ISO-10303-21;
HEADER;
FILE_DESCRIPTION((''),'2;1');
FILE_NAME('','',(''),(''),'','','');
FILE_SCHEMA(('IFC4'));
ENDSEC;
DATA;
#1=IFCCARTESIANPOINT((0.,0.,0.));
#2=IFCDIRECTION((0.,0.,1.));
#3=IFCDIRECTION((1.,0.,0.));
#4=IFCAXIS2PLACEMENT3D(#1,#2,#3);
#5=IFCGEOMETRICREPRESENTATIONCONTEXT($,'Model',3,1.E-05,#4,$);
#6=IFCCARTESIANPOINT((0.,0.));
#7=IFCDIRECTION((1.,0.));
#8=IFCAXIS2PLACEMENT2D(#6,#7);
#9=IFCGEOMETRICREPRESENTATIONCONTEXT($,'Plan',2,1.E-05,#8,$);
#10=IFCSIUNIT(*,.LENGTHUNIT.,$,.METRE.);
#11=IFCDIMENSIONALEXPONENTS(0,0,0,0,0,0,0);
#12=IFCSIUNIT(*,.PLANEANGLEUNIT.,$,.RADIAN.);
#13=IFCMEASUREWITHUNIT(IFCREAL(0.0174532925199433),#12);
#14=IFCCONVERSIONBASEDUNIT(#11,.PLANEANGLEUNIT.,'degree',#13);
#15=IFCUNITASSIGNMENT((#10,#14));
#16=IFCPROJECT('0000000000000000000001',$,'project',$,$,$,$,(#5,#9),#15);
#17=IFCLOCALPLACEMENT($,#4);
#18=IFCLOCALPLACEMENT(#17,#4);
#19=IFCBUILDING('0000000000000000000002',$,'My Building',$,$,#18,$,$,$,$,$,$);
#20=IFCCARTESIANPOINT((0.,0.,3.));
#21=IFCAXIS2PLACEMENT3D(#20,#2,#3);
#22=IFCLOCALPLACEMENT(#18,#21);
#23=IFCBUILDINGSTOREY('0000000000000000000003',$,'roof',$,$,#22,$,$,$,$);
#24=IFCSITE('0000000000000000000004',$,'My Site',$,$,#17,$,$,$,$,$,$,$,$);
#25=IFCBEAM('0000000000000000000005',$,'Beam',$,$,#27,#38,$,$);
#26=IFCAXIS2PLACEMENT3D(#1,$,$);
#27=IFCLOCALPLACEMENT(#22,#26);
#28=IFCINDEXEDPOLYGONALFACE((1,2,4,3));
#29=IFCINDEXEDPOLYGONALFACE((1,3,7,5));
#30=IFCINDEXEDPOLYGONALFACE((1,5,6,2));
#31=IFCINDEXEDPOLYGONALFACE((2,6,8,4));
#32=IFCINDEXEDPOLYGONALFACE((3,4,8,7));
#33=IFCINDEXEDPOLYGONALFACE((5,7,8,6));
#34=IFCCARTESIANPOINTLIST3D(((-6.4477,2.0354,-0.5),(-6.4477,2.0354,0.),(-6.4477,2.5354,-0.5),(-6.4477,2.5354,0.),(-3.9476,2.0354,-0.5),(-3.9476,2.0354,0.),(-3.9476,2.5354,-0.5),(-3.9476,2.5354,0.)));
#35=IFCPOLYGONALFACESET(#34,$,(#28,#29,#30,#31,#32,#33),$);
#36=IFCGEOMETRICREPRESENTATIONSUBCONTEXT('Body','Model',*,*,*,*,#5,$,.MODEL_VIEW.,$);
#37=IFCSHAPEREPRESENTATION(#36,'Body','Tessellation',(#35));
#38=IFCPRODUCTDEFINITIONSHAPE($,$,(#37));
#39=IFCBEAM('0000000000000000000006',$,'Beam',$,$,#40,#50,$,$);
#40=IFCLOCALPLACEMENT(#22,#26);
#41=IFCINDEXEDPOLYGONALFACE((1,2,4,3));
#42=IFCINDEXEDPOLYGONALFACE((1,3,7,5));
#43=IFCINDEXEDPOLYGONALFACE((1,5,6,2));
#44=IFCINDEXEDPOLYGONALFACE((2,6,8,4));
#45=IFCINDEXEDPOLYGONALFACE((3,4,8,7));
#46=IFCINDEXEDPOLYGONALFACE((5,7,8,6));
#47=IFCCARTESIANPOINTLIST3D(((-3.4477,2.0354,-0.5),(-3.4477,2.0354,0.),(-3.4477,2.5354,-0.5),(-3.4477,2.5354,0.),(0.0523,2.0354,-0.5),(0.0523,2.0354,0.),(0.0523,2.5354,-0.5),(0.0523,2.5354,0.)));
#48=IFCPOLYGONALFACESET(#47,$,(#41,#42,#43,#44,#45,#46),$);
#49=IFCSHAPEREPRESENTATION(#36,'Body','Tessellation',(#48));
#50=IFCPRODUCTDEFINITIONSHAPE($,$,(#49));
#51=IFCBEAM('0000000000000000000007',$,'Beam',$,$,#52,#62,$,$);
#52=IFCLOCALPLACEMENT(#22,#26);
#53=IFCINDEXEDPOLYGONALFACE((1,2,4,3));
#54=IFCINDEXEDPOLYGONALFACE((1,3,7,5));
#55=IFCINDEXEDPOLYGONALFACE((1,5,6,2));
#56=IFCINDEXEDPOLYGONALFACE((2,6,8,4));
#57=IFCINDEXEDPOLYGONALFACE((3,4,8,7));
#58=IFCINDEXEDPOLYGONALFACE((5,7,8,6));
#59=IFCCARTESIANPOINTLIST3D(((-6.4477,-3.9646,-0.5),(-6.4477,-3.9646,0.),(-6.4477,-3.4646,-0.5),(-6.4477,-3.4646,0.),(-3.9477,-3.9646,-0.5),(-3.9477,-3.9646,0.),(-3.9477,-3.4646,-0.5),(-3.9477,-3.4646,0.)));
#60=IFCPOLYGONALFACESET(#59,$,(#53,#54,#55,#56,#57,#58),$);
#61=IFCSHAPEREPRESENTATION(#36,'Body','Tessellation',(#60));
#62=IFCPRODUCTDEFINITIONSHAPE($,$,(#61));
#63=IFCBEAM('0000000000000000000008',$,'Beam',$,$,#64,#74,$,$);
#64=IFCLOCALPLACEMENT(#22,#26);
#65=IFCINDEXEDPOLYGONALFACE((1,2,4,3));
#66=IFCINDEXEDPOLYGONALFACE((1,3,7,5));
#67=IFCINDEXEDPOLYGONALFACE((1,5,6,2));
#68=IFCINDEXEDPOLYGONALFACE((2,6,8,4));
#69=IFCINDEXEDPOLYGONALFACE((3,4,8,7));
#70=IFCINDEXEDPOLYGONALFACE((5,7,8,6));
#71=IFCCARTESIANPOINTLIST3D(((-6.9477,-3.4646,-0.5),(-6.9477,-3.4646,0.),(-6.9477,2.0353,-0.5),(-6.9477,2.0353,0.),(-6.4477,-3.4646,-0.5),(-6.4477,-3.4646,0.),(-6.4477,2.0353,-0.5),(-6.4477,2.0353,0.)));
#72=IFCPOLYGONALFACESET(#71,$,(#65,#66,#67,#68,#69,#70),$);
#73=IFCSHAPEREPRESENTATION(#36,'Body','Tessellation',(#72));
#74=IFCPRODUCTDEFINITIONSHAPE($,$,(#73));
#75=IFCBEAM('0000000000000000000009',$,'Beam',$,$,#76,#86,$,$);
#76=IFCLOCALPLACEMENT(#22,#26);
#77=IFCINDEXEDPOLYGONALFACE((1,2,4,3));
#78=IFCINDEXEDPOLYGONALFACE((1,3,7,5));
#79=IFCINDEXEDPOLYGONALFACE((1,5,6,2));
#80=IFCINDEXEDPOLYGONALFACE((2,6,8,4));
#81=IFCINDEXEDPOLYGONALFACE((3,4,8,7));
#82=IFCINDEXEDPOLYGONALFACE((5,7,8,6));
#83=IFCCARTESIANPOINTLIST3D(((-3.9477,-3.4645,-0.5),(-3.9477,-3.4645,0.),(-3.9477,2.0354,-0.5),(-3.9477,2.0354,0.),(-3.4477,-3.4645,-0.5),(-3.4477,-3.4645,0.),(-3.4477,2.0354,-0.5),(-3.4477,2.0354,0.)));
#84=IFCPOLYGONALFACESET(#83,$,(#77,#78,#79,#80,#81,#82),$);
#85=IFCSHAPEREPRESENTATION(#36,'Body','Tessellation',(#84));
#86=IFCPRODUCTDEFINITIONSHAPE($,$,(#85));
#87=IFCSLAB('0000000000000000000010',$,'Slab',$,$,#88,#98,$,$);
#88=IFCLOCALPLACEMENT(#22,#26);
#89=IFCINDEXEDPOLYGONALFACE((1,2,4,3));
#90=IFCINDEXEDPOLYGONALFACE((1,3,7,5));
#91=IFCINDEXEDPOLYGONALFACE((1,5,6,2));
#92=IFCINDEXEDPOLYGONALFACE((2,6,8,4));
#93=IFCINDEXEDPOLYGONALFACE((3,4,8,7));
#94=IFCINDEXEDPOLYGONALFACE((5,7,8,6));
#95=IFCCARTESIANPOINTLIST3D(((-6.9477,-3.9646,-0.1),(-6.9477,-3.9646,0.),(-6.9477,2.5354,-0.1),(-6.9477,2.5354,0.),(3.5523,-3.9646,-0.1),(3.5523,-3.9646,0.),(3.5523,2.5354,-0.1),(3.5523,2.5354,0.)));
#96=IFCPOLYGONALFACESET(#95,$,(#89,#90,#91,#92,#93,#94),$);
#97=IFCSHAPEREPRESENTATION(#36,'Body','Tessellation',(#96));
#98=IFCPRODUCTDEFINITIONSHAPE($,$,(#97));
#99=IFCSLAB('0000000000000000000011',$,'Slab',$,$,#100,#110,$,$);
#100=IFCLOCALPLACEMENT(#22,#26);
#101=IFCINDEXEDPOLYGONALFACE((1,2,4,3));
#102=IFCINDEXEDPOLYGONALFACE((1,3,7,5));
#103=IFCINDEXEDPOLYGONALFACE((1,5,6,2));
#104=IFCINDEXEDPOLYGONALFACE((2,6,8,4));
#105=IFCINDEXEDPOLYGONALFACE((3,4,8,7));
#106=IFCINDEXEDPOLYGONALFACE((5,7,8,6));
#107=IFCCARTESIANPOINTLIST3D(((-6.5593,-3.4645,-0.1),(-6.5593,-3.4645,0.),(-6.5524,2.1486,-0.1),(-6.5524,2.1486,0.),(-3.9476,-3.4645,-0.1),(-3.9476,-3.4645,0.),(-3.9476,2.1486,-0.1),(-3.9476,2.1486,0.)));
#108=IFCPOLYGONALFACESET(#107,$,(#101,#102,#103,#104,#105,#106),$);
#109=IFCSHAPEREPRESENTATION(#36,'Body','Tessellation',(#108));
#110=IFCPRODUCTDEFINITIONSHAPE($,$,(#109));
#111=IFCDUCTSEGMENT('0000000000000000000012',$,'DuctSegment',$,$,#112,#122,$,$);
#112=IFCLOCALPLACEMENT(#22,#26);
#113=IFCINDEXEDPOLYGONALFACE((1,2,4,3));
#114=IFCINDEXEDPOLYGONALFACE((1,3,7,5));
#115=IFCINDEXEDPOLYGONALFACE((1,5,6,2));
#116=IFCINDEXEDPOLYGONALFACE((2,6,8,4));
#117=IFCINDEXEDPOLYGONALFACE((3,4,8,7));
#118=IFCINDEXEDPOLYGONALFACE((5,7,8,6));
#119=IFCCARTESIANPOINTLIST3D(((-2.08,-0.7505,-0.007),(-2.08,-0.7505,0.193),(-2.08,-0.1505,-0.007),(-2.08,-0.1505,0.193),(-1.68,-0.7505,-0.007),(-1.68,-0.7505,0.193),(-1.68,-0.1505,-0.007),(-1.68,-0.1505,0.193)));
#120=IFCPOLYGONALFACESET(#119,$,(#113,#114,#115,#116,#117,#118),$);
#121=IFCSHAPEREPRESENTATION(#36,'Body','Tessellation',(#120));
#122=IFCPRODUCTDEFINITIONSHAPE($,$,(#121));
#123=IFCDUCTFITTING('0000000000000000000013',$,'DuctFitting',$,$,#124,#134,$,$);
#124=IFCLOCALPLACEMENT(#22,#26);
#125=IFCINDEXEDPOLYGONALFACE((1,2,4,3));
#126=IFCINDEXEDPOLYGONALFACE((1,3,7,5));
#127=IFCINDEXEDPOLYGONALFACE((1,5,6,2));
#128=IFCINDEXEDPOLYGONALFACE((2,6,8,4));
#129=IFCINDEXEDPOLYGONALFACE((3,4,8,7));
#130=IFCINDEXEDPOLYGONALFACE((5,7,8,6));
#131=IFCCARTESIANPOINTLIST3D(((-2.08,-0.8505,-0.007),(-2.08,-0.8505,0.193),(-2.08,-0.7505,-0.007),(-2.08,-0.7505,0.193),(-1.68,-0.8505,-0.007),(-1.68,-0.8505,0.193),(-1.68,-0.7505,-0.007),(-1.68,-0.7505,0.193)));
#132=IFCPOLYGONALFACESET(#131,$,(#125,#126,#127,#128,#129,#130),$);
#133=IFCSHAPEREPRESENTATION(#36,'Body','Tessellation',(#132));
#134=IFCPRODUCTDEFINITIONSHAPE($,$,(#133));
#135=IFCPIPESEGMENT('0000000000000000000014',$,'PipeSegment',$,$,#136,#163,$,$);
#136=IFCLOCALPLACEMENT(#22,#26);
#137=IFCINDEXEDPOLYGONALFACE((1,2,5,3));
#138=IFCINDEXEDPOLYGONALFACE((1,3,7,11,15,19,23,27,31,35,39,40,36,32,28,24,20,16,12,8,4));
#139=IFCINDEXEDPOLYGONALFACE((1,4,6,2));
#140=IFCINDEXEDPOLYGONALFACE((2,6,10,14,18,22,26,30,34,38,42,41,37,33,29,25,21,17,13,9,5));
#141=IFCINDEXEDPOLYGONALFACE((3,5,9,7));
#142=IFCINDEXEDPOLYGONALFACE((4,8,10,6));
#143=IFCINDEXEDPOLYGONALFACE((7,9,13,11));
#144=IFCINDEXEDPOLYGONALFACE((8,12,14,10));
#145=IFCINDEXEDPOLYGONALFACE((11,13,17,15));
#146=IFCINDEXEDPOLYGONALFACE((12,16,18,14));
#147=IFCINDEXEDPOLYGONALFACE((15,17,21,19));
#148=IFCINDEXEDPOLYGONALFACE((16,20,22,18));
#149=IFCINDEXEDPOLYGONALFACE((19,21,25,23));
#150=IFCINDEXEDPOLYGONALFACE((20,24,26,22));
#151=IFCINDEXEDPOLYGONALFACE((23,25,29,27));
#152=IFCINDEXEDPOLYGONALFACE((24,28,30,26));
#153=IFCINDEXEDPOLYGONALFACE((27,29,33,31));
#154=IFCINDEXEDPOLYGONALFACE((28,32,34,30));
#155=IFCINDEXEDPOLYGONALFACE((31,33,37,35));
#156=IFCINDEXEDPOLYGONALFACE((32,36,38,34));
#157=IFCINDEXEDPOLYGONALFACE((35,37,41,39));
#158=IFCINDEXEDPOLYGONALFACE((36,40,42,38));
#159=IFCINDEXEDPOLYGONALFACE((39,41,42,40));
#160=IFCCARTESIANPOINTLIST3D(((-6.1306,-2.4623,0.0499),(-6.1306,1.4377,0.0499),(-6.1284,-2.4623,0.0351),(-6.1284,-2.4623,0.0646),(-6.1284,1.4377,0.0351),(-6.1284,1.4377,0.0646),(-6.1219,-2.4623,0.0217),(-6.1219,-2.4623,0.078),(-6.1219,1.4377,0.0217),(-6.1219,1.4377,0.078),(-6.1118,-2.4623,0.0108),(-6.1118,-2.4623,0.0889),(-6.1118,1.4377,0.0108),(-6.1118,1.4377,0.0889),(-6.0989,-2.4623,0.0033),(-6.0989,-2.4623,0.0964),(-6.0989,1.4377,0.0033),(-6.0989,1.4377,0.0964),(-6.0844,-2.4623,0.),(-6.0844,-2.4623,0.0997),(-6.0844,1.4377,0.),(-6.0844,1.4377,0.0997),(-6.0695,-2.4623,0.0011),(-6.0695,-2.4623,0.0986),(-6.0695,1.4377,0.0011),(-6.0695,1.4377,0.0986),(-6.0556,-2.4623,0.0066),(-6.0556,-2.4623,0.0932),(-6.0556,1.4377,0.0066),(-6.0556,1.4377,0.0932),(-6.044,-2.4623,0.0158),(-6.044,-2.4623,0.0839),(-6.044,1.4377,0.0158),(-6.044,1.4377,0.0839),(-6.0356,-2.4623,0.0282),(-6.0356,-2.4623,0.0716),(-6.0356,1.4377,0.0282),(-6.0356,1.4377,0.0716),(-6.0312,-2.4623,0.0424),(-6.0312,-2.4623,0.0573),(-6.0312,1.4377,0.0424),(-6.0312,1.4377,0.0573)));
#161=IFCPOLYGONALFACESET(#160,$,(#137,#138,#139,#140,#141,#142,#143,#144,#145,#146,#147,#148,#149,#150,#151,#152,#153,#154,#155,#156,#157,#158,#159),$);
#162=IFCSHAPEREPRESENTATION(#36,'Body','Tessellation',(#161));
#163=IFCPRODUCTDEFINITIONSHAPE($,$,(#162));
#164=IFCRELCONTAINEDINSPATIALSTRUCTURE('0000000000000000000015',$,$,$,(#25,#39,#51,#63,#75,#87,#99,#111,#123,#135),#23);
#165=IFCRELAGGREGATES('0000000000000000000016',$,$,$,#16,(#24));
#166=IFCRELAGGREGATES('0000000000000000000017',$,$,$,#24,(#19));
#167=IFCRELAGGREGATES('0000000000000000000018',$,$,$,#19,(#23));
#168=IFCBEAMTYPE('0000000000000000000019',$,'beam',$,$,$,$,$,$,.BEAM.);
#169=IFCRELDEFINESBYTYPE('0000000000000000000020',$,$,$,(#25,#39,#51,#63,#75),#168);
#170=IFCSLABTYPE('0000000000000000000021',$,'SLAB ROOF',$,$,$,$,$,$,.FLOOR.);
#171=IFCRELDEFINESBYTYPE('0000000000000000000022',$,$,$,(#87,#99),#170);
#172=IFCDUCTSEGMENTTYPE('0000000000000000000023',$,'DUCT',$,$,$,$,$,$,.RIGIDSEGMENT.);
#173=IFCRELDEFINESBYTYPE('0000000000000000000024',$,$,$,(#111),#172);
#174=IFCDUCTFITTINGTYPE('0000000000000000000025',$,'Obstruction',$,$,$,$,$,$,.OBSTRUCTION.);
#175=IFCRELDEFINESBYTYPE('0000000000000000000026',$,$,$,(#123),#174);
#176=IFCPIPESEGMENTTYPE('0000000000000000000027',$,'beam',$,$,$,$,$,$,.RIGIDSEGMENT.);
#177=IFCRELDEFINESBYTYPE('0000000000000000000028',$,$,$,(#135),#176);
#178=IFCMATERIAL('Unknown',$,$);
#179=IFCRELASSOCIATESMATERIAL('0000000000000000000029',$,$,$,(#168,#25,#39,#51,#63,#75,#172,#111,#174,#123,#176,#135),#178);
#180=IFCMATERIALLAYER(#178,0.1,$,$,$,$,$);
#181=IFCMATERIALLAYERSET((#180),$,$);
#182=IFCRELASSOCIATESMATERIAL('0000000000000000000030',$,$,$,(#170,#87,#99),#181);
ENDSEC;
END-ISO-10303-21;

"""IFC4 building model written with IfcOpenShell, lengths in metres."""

from ifc_helpers import new_model, entity, si_unit, converted_unit, frame, origin_with_axes, origin_2d_with_axis, place, context, subcontext, project, spatial, indexed_curve, rectangle, circle, outline, extrude, material, layer, layer_set, layer_usage, material_profile, profile_set, profile_usage, type_object, element, save


model = new_model("IFC4")

# Units and contexts
model_context = context("Model", 3, precision=1e-05, world=origin_with_axes())
plan_context = context("Plan", 2, precision=1e-05, world=origin_2d_with_axis())
body_context = subcontext(model_context, "Body", "Model", "MODEL_VIEW")
ifc_project = project(units=[si_unit("LENGTHUNIT", "METRE"), converted_unit("PLANEANGLEUNIT", "degree", entity("IfcReal", 0.0174532925199433), si_unit("PLANEANGLEUNIT", "RADIAN"), dimensions=[0, 0, 0, 0, 0, 0, 0])], contexts=[model_context, plan_context])

# Site, building, storey
site_placement = place(None, origin_with_axes())
site = spatial("IfcSite", under=ifc_project, at=site_placement, Name="My Site")
building_placement = place(site_placement, origin_with_axes())
building = spatial("IfcBuilding", under=site, at=building_placement, Name="My Building")
storey_placement = place(building_placement, frame((0.0, 0.0, 3.0), z_axis=(0.0, 0.0, 1.0), x_axis=(1.0, 0.0, 0.0)))
storey = spatial("IfcBuildingStorey", under=building, at=storey_placement, Name="roof")

# Beams
ifc_material = material(Name="Unknown")
ifc_material_profile_1 = material_profile(ifc_material, rectangle(XDim=0.5, YDim=0.5))
ifc_profile_set_1 = profile_set([ifc_material_profile_1])
ifc_profile_usage_1 = profile_usage(ifc_profile_set_1, cardinal=7)
beam_type = type_object("IfcBeamType", Name="beam", PredefinedType="BEAM", material=ifc_profile_set_1)
beam_1_placement = place(storey_placement, frame((-6.4477, 2.5354, 0.0), z_axis=(1.0, 0.0, 0.0), x_axis=(0.0, 1.0, 0.0)))
element("IfcBeam", 1, at=beam_1_placement, inside=storey, type_object=beam_type, material=ifc_profile_usage_1, Name="Beam", context=body_context, shape_type="SweptSolid", body=[
    extrude(rectangle(XDim=0.5, YDim=0.5), frame((-0.25, -0.25, 0.0), z_axis=(0.0, 0.0, 1.0), x_axis=(1.0, 0.0, 0.0)), (0.0, 0.0, 1.0), 2.5001),
])
ifc_profile_usage_2 = profile_usage(ifc_profile_set_1, cardinal=7)
beam_2_placement = place(storey_placement, frame((-3.4477, 2.5354, 0.0), z_axis=(1.0, 0.0, 0.0), x_axis=(0.0, 1.0, 0.0)))
element("IfcBeam", 2, at=beam_2_placement, inside=storey, type_object=beam_type, material=ifc_profile_usage_2, Name="Beam", context=body_context, shape_type="SweptSolid", body=[
    extrude(rectangle(XDim=0.5, YDim=0.5), frame((-0.25, -0.25, 0.0), z_axis=(0.0, 0.0, 1.0), x_axis=(1.0, 0.0, 0.0)), (0.0, 0.0, 1.0), 3.5),
])
ifc_profile_usage_3 = profile_usage(ifc_profile_set_1, cardinal=7)
beam_3_placement = place(storey_placement, frame((-3.9477, -3.9646, 0.0), z_axis=(-1.0, -0.000001, 0.000001), x_axis=(0.000001, -1.0, 0.0)))
element("IfcBeam", 3, at=beam_3_placement, inside=storey, type_object=beam_type, material=ifc_profile_usage_3, Name="Beam", context=body_context, shape_type="SweptSolid", body=[
    extrude(rectangle(XDim=0.5, YDim=0.5), frame((-0.25, -0.25, 0.0), z_axis=(0.0, 0.0, 1.0), x_axis=(1.0, 0.0, 0.0)), (0.0, 0.0, 1.0), 2.5),
])
ifc_profile_usage_4 = profile_usage(ifc_profile_set_1, cardinal=7)
beam_4_placement = place(storey_placement, frame((-6.4477, 2.0353, 0.0), z_axis=(0.0, -1.0, 0.0), x_axis=(1.0, 0.0, 0.0)))
element("IfcBeam", 4, at=beam_4_placement, inside=storey, type_object=beam_type, material=ifc_profile_usage_4, Name="Beam", context=body_context, shape_type="SweptSolid", body=[
    extrude(rectangle(XDim=0.5, YDim=0.5), frame((-0.25, -0.25, 0.0), z_axis=(0.0, 0.0, 1.0), x_axis=(1.0, 0.0, 0.0)), (0.0, 0.0, 1.0), 5.4999),
])
ifc_profile_usage_5 = profile_usage(ifc_profile_set_1, cardinal=7)
beam_5_placement = place(storey_placement, frame((-3.4477, 2.0354, 0.0), z_axis=(0.0, -1.0, 0.0), x_axis=(1.0, 0.0, 0.0)))
element("IfcBeam", 5, at=beam_5_placement, inside=storey, type_object=beam_type, material=ifc_profile_usage_5, Name="Beam", context=body_context, shape_type="SweptSolid", body=[
    extrude(rectangle(XDim=0.5, YDim=0.5), frame((-0.25, -0.25, 0.0), z_axis=(0.0, 0.0, 1.0), x_axis=(1.0, 0.0, 0.0)), (0.0, 0.0, 1.0), 5.4999),
])

# Slabs
ifc_layer = layer(ifc_material, 0.1)
ifc_layer_set = layer_set([ifc_layer])
ifc_layer_usage_1 = layer_usage(ifc_layer_set, "AXIS3", "POSITIVE", -0.1)
slab_type = type_object("IfcSlabType", Name="SLAB ROOF", PredefinedType="FLOOR", material=ifc_layer_set)
slab_1_placement = place(storey_placement, frame((-6.9477, 2.5354, 0.0), z_axis=(0.0, 0.0, 1.0), x_axis=(1.0, 0.0, 0.0)))
element("IfcSlab", 6, at=slab_1_placement, inside=storey, type_object=slab_type, material=ifc_layer_usage_1, Name="Slab", context=body_context, shape_type="SweptSolid", body=[
    extrude(outline(indexed_curve([(0.0, 0.0), (10.5, 0.0), (10.5, -6.5), (0.0, -6.5), (0.0, 0.0)])), frame((0.0, 0.0, -0.1), z_axis=(0.0, 0.0, 1.0), x_axis=(1.0, 0.0, 0.0)), (0.0, 0.0, 1.0), 0.1),
])
ifc_layer_usage_2 = layer_usage(ifc_layer_set, "AXIS3", "POSITIVE", -0.1)
slab_2_placement = place(storey_placement, frame((-6.5524, 2.1486, 0.0), z_axis=(0.0, 0.0, 1.0), x_axis=(1.0, 0.0, 0.0)))
element("IfcSlab", 7, at=slab_2_placement, inside=storey, type_object=slab_type, material=ifc_layer_usage_2, Name="Slab", context=body_context, shape_type="SweptSolid", body=[
    extrude(outline(indexed_curve([(0.0, 0.0), (2.6047, 0.0), (2.6047, -5.6131), (-0.007, -5.6131), (0.0, 0.0)])), frame((0.0, 0.0, -0.1), z_axis=(0.0, 0.0, 1.0), x_axis=(1.0, 0.0, 0.0)), (0.0, 0.0, 1.0), 0.1),
])

# Duct segment
ifc_material_profile_2 = material_profile(ifc_material, rectangle(XDim=0.4, YDim=0.2))
ifc_profile_set_2 = profile_set([ifc_material_profile_2])
ifc_profile_usage_6 = profile_usage(ifc_profile_set_2, cardinal=5)
duct_segment_type = type_object("IfcDuctSegmentType", Name="DUCT", PredefinedType="RIGIDSEGMENT", material=ifc_profile_set_2)
duct_segment_placement = place(storey_placement, frame((-1.88, -0.7505, 0.093), z_axis=(0.0, 1.0, 0.000008), x_axis=(-1.0, 0.0, 0.0)))
element("IfcDuctSegment", 8, at=duct_segment_placement, inside=storey, type_object=duct_segment_type, material=ifc_profile_usage_6, Name="DuctSegment", context=body_context, shape_type="SweptSolid", body=[
    extrude(rectangle(XDim=0.4, YDim=0.2), origin_with_axes(), (0.0, 0.0, 1.0), 0.6),
])

# Duct fitting
ifc_material_profile_3 = material_profile(ifc_material, rectangle(XDim=0.4, YDim=0.2))
ifc_profile_set_3 = profile_set([ifc_material_profile_3])
ifc_profile_usage_7 = profile_usage(ifc_profile_set_3, cardinal=5)
duct_fitting_type = type_object("IfcDuctFittingType", Name="Obstruction", PredefinedType="OBSTRUCTION", material=ifc_profile_set_3)
duct_fitting_placement = place(storey_placement, frame((-1.88, -0.8505, 0.093), z_axis=(0.0, 1.0, 0.000008), x_axis=(-1.0, 0.0, 0.0)))
element("IfcDuctFitting", 9, at=duct_fitting_placement, inside=storey, type_object=duct_fitting_type, material=ifc_profile_usage_7, Name="DuctFitting", context=body_context, shape_type="SweptSolid", body=[
    extrude(rectangle(XDim=0.4, YDim=0.2), origin_with_axes(), (0.0, 0.0, 1.0), 0.1),
])

# Pipe segment
ifc_material_profile_4 = material_profile(ifc_material, circle(Radius=0.05))
ifc_profile_set_4 = profile_set([ifc_material_profile_4])
ifc_profile_usage_8 = profile_usage(ifc_profile_set_4, cardinal=7)
pipe_segment_type = type_object("IfcPipeSegmentType", Name="beam", PredefinedType="RIGIDSEGMENT", material=ifc_profile_set_4)
pipe_segment_1_placement = place(storey_placement, frame((-6.1306, -2.4623, 0.0999), z_axis=(0.0, 1.0, 0.0), x_axis=(-1.0, 0.0, 0.0)))
element("IfcPipeSegment", 10, at=pipe_segment_1_placement, inside=storey, type_object=pipe_segment_type, material=ifc_profile_usage_8, Name="PipeSegment", context=body_context, shape_type="SweptSolid", body=[
    extrude(circle(Radius=0.05), frame((-0.05, -0.05, 0.0), z_axis=(0.0, 0.0, 1.0), x_axis=(1.0, 0.0, 0.0)), (0.0, 0.0, 1.0), 3.9),
])

save(model, "model.ifc")
